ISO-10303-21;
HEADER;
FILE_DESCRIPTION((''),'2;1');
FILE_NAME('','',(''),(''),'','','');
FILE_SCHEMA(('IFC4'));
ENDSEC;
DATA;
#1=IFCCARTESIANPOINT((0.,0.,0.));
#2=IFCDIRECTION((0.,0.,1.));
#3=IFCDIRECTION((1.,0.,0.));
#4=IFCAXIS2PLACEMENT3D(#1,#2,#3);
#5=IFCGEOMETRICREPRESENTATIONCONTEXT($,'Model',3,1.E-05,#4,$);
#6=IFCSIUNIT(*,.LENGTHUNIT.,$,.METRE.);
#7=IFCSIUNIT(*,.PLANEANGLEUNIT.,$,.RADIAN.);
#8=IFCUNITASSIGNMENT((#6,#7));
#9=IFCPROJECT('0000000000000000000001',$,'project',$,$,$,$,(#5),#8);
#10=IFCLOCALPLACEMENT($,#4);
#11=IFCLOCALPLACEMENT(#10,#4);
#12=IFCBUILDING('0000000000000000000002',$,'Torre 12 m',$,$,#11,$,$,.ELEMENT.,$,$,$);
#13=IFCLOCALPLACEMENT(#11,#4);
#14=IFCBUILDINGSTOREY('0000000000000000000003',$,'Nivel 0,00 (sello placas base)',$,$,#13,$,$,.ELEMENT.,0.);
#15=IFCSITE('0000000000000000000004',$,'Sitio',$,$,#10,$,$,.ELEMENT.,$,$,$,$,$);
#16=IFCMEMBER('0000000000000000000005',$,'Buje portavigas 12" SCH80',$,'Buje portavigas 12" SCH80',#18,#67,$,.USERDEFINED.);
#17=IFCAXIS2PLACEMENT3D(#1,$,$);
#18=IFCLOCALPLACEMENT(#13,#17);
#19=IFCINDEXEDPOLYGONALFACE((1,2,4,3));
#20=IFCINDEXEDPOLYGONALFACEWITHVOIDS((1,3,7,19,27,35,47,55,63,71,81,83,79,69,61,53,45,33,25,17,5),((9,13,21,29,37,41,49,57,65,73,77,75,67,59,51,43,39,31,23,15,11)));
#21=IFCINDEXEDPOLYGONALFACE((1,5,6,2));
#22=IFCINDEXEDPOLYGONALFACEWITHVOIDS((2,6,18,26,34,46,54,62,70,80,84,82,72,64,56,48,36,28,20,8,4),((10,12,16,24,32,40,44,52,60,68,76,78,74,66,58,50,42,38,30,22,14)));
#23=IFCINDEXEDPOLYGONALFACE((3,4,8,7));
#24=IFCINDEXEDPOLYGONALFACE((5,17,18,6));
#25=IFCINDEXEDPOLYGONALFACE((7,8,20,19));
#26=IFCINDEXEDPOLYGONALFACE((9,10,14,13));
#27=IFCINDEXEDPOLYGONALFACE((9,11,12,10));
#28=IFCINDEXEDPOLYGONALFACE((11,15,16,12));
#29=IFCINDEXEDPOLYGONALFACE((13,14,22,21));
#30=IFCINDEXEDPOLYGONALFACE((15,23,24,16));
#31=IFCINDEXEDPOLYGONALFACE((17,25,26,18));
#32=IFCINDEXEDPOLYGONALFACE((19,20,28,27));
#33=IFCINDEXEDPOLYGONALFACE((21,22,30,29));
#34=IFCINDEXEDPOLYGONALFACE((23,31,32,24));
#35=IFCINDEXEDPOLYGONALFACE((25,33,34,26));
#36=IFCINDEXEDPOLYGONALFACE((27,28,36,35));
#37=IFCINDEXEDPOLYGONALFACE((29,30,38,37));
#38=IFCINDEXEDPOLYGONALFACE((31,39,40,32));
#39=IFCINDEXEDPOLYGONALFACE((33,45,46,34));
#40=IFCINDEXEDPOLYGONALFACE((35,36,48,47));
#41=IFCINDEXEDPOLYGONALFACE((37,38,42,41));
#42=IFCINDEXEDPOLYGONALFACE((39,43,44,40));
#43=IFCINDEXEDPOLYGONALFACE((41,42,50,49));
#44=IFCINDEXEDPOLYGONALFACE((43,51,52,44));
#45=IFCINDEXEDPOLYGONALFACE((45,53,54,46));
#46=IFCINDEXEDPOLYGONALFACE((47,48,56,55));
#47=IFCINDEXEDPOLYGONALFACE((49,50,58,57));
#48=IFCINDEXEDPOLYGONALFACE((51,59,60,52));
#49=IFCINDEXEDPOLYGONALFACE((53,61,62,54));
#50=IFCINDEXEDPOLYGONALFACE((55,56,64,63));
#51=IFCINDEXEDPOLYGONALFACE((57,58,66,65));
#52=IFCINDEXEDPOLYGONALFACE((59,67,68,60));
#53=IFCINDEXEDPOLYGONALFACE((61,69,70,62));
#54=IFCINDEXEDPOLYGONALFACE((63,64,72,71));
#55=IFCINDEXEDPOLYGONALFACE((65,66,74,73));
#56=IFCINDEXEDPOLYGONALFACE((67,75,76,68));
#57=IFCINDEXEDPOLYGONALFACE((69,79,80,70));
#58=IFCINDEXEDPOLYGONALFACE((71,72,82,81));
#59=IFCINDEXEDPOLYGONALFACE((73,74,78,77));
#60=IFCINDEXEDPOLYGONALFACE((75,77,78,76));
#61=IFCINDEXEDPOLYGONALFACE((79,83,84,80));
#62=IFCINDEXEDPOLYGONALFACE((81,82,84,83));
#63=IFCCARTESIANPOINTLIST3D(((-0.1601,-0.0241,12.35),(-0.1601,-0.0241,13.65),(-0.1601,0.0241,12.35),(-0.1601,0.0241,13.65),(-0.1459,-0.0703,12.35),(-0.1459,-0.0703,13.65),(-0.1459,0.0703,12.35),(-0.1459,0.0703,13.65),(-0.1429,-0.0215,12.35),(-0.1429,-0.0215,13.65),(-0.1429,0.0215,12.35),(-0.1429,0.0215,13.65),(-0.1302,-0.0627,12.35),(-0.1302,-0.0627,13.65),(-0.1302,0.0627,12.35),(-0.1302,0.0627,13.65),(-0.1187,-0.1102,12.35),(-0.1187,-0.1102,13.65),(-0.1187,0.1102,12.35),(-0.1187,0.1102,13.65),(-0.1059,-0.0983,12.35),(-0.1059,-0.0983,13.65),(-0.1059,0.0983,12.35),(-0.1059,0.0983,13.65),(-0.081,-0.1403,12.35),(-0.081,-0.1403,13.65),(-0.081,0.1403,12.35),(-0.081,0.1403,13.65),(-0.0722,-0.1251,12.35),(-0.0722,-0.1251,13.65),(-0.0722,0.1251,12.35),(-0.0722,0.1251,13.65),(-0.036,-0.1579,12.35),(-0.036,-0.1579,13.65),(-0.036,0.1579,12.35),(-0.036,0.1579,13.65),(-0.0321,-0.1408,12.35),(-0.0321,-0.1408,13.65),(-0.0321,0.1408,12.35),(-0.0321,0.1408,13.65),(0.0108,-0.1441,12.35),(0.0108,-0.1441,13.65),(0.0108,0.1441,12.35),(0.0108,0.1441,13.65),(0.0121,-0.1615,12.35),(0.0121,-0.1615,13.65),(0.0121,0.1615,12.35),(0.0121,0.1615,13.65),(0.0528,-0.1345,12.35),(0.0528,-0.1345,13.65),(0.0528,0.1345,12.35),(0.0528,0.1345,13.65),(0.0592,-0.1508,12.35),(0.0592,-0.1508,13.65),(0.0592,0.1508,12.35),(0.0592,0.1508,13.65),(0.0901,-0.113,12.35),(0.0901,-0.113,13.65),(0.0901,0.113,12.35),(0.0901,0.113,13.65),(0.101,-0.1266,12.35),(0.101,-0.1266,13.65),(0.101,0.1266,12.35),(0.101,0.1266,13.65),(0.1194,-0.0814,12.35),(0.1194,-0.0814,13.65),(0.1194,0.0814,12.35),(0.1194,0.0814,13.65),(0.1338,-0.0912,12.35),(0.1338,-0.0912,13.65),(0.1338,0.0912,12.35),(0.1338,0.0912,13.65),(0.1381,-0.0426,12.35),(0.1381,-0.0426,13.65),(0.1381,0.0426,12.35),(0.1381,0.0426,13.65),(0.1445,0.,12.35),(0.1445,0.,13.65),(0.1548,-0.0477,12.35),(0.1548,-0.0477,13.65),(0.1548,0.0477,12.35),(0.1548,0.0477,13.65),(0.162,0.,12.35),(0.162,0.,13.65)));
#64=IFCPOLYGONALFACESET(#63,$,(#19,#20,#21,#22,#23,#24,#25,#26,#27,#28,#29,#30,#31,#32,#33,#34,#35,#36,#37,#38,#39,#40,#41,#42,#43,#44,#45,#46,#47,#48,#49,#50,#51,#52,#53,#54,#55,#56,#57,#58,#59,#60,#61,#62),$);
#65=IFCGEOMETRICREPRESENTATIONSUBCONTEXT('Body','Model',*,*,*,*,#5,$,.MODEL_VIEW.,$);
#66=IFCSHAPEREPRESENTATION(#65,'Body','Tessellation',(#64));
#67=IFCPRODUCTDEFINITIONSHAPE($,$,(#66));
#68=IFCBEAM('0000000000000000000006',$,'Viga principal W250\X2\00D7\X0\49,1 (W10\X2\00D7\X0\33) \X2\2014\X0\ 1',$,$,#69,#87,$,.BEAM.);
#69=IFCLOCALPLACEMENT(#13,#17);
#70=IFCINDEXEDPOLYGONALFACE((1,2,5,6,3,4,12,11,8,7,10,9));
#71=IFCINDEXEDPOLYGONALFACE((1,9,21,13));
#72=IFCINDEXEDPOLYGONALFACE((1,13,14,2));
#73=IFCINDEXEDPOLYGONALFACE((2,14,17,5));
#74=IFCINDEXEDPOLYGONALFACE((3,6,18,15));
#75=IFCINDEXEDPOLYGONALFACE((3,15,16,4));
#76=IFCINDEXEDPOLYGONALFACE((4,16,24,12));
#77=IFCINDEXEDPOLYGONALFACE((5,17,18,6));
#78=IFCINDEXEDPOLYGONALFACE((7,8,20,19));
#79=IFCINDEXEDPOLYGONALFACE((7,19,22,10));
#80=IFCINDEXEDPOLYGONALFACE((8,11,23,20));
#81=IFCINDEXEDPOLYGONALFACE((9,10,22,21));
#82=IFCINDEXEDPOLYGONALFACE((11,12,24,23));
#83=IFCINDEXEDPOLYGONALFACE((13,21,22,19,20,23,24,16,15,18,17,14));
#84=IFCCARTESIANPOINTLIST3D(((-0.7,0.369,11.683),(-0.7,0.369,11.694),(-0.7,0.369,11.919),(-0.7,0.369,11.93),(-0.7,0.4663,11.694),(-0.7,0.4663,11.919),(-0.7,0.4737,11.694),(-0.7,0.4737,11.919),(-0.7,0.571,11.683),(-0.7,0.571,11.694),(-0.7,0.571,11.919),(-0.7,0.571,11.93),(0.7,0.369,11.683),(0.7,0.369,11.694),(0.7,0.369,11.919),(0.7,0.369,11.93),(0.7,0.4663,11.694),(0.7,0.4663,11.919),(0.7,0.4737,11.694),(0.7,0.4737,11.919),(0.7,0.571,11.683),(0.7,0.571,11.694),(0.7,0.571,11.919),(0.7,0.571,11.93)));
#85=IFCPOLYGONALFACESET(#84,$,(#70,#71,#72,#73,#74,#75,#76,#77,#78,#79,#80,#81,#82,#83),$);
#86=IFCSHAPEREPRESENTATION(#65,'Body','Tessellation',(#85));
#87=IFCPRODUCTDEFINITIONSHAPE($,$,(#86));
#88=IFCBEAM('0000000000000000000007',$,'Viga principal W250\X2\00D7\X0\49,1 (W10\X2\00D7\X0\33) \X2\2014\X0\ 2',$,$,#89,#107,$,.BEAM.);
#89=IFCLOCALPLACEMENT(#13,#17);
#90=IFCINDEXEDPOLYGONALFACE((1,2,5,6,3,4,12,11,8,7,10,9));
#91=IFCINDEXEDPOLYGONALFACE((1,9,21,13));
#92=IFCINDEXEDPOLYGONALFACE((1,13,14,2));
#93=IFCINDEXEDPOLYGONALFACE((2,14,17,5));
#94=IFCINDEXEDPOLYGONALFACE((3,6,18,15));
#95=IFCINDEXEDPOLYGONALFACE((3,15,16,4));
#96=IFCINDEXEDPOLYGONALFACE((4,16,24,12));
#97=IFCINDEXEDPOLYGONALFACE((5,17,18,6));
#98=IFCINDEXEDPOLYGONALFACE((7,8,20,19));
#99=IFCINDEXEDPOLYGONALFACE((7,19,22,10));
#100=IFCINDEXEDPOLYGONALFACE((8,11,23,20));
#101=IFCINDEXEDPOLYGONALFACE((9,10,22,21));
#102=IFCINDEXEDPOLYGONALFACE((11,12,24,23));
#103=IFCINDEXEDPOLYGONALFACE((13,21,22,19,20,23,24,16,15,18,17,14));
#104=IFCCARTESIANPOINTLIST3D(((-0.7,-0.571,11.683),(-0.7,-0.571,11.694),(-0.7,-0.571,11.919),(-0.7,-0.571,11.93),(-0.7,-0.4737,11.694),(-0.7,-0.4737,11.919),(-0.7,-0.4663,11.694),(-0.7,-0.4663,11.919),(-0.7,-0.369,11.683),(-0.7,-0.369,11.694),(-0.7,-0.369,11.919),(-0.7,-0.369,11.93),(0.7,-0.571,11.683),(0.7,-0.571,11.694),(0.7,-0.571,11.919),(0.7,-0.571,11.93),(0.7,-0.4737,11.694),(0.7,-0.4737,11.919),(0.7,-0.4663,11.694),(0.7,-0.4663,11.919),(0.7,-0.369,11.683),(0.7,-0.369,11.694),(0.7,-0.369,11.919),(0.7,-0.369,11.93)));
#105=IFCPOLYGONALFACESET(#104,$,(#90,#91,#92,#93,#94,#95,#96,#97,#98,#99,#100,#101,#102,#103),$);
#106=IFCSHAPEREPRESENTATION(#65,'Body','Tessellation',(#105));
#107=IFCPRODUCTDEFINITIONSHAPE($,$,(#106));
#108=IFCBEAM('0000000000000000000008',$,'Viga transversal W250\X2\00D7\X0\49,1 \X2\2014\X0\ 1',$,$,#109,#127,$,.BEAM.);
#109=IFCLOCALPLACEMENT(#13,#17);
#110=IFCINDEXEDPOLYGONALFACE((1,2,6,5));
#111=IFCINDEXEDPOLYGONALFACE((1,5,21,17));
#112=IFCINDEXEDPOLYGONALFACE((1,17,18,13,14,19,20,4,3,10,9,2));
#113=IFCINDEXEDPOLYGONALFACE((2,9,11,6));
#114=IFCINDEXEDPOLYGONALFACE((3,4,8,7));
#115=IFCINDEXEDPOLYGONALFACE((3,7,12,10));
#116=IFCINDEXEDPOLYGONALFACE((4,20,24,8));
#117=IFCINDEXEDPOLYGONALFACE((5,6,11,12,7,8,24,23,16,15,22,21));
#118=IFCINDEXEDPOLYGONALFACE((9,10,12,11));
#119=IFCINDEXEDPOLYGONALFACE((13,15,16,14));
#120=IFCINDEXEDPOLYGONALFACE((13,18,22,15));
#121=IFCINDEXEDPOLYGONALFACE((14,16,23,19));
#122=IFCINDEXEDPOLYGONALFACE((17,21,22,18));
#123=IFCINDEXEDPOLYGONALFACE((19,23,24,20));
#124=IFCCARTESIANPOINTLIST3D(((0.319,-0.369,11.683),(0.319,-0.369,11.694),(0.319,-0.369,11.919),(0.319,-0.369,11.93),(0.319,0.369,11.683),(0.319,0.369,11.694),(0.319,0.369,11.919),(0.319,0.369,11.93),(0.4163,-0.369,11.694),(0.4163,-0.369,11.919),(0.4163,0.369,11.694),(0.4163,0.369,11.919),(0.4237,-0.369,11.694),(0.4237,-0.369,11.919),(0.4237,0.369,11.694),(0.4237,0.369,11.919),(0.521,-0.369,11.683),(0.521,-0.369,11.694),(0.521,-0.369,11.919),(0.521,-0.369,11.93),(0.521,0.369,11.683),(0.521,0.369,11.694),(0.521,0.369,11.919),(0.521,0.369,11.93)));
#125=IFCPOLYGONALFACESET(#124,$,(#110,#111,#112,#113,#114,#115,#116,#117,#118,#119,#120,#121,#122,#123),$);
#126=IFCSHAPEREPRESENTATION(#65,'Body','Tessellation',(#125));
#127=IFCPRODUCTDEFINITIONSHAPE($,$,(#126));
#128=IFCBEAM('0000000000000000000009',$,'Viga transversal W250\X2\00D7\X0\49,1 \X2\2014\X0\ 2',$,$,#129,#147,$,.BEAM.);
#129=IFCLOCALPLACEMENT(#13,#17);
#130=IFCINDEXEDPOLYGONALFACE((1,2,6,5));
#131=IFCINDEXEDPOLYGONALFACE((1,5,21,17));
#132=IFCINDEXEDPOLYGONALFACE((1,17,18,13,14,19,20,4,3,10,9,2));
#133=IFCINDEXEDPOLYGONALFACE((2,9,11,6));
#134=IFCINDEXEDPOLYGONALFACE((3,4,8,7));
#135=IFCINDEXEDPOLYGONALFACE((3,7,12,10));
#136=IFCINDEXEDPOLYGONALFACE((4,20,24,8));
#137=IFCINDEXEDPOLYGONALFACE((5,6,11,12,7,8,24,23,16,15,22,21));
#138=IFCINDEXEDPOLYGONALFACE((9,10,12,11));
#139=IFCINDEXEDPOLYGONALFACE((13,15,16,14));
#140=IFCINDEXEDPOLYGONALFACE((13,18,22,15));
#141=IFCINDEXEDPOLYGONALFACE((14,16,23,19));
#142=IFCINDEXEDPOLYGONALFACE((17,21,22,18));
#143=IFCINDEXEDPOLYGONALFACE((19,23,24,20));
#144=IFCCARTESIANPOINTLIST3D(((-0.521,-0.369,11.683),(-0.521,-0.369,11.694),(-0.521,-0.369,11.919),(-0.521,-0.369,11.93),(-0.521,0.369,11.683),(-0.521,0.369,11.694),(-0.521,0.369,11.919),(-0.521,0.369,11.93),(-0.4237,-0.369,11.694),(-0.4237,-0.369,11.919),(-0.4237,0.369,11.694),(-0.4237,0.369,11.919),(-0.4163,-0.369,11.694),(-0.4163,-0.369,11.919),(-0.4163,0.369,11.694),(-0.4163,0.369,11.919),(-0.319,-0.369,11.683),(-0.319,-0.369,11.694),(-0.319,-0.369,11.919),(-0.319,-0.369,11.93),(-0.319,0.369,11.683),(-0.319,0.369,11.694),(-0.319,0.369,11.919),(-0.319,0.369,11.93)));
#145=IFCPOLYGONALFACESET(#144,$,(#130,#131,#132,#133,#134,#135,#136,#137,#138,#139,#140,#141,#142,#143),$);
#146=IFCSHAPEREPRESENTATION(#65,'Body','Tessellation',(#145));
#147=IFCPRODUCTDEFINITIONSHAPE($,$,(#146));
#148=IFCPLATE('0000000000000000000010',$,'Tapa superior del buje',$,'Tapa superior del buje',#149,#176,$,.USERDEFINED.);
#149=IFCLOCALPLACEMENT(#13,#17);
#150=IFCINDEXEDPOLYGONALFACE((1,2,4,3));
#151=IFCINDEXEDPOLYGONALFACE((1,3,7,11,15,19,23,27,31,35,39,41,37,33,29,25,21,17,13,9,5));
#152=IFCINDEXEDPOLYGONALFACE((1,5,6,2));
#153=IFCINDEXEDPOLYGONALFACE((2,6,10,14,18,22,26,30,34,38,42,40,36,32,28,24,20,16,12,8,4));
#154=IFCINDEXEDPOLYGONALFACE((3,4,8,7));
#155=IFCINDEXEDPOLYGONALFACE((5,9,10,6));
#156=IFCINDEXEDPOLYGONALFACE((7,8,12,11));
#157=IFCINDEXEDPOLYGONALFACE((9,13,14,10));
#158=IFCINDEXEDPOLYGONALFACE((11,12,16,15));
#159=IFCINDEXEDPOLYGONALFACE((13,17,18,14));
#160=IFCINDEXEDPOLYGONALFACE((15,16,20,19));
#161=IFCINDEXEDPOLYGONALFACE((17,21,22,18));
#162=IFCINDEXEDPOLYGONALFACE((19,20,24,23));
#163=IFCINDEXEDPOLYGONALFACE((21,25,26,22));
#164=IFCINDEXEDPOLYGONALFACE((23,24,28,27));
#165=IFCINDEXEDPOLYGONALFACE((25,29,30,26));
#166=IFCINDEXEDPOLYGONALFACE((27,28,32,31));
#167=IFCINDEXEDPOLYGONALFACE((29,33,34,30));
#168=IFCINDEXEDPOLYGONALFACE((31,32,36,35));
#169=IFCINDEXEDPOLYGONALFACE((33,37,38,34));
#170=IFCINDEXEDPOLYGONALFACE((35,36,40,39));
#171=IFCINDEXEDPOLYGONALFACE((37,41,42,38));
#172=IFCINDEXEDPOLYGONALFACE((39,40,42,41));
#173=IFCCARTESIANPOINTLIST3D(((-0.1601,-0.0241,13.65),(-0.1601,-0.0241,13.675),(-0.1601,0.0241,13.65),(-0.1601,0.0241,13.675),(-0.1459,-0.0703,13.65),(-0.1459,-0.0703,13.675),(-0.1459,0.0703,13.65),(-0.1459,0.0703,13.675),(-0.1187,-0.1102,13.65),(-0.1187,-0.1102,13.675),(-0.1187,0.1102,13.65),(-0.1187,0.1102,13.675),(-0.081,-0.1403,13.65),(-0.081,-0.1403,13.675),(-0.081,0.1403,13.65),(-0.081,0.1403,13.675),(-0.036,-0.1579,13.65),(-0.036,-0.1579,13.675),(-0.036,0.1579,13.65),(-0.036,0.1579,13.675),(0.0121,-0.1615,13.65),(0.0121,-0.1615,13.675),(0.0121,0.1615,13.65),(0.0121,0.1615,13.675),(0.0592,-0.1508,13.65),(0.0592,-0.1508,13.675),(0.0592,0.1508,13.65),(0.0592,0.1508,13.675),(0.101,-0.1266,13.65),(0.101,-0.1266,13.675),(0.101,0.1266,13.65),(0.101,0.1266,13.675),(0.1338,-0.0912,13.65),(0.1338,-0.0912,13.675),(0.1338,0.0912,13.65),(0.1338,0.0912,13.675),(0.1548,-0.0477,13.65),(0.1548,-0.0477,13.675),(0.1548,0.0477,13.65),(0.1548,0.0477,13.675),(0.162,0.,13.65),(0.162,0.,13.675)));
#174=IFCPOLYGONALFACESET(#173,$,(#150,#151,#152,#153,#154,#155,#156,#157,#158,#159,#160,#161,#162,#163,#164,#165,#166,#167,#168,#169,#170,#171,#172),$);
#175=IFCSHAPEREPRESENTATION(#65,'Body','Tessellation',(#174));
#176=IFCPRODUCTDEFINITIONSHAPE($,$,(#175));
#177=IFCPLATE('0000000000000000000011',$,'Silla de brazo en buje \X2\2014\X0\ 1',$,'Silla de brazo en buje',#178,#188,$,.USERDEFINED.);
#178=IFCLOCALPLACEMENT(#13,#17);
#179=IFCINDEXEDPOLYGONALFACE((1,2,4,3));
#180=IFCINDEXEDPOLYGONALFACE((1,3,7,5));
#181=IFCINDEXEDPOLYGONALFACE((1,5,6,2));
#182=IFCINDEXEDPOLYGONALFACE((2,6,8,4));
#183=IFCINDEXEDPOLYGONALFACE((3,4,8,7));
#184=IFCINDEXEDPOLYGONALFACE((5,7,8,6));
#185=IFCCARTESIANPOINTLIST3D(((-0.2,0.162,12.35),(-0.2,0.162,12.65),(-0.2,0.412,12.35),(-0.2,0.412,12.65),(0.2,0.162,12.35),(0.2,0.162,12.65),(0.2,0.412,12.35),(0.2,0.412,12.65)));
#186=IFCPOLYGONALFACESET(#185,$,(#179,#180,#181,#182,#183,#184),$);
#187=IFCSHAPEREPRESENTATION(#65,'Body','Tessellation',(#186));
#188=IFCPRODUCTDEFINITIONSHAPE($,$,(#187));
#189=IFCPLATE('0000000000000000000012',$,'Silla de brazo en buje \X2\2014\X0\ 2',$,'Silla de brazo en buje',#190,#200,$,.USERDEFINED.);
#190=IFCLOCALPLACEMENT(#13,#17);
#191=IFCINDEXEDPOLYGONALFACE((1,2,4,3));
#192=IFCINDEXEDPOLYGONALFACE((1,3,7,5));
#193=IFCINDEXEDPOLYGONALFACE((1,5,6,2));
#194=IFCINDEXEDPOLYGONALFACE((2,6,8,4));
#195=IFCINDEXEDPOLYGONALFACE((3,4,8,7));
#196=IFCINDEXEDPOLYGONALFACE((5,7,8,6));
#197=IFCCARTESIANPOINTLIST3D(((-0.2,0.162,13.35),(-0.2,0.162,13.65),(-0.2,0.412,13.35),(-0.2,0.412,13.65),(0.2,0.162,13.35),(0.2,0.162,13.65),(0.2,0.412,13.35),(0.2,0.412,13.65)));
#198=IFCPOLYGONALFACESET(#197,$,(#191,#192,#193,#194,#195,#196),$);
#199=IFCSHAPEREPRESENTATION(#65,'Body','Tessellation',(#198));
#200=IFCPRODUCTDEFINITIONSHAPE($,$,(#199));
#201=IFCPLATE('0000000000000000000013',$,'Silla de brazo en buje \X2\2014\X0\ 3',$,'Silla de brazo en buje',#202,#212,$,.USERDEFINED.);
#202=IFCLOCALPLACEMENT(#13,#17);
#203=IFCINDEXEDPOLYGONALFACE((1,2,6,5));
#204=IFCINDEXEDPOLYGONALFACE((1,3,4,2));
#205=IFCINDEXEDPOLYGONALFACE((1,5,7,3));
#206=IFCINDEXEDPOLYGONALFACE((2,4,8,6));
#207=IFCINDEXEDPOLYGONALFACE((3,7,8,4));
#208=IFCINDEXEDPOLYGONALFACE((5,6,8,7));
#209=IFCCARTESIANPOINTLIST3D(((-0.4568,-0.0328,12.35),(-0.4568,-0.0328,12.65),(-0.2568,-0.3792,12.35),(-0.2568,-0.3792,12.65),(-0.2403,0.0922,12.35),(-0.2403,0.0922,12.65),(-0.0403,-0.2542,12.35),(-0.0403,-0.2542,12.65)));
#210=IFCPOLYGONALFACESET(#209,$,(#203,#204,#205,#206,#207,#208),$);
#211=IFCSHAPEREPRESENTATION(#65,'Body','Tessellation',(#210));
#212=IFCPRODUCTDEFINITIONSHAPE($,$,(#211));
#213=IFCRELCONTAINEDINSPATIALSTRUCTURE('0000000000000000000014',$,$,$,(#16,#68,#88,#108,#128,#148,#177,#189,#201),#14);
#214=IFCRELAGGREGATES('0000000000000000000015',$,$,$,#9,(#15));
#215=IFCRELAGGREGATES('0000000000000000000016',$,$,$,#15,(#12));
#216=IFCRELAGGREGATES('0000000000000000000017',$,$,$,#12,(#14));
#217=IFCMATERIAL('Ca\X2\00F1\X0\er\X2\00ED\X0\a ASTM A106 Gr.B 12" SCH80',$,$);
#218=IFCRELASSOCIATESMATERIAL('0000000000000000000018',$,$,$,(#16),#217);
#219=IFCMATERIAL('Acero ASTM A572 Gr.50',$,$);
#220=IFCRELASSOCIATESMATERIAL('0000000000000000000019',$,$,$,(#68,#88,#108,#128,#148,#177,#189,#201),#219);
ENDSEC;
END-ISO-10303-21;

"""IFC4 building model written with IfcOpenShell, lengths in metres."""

from ifc_helpers import new_model, si_unit, frame, origin, origin_with_axes, origin_2d, place, context, subcontext, project, spatial, rectangle, circle, hollow_circle, i_section, extrude, material, element, save


model = new_model("IFC4")

# Units and contexts
model_context = context("Model", 3, precision=1e-05, world=origin_with_axes())
body_context = subcontext(model_context, "Body", "Model", "MODEL_VIEW")
ifc_project = project(units=[si_unit("LENGTHUNIT", "METRE"), si_unit("PLANEANGLEUNIT", "RADIAN")], contexts=[model_context])

# Site, building, storey
site_placement = place(None, origin_with_axes())
site = spatial("IfcSite", under=ifc_project, at=site_placement, Name="Sitio", CompositionType="ELEMENT")
building_placement = place(site_placement, origin_with_axes())
building = spatial("IfcBuilding", under=site, at=building_placement, Name="Torre 12 m", CompositionType="ELEMENT")
storey_placement = place(building_placement, origin_with_axes())
storey = spatial("IfcBuildingStorey", under=building, at=storey_placement, Name="Nivel 0,00 (sello placas base)", CompositionType="ELEMENT", Elevation=0.0)

# Member
ifc_material_1 = material(Name="Cañería ASTM A106 Gr.B 12\" SCH80")
member_placement = place(storey_placement, frame((0.0, 0.0, 12.35), z_axis=(0.0, 0.0, 1.0), x_axis=(1.0, 0.0, 0.0)))
element("IfcMember", 1, at=member_placement, inside=storey, material=ifc_material_1, Name="Buje portavigas 12\" SCH80", ObjectType="Buje portavigas 12\" SCH80", PredefinedType="USERDEFINED", context=body_context, shape_type="SweptSolid", body=[
    extrude(hollow_circle(Radius=0.162, WallThickness=0.0175, at=origin_2d()), origin(), (0.0, 0.0, 1.0), 1.3),
])

# Beams
ifc_material_2 = material(Name="Acero ASTM A572 Gr.50")
for number, where, z_axis, x_axis, name in (
    (2, (-0.7, 0.47, 11.8065), (1.0, 0.0, 0.0), (0.0, 1.0, 0.0), "Viga principal W250×49,1 (W10×33) — 1"),
    (3, (-0.7, -0.47, 11.8065), (1.0, 0.0, 0.0), (0.0, 1.0, 0.0), "Viga principal W250×49,1 (W10×33) — 2"),
):
    element("IfcBeam", number, at=place(storey_placement, frame(where, z_axis=z_axis, x_axis=x_axis)), inside=storey, material=ifc_material_2, Name=name, PredefinedType="BEAM", context=body_context, shape_type="SweptSolid", body=[
        extrude(i_section(OverallWidth=0.202, OverallDepth=0.247, WebThickness=0.0074, FlangeThickness=0.011, at=origin_2d()), origin(), (0.0, 0.0, 1.0), 1.4),
    ])
for number, where, z_axis, x_axis, name in (
    (4, (0.42, -0.369, 11.8065), (0.0, 1.0, 0.0), (1.0, 0.0, 0.0), "Viga transversal W250×49,1 — 1"),
    (5, (-0.42, -0.369, 11.8065), (0.0, 1.0, 0.0), (1.0, 0.0, 0.0), "Viga transversal W250×49,1 — 2"),
):
    element("IfcBeam", number, at=place(storey_placement, frame(where, z_axis=z_axis, x_axis=x_axis)), inside=storey, material=ifc_material_2, Name=name, PredefinedType="BEAM", context=body_context, shape_type="SweptSolid", body=[
        extrude(i_section(OverallWidth=0.202, OverallDepth=0.247, WebThickness=0.0074, FlangeThickness=0.011, at=origin_2d()), origin(), (0.0, 0.0, 1.0), 0.738),
    ])

# Plates
plate_1_placement = place(storey_placement, frame((0.0, 0.0, 13.65), z_axis=(0.0, 0.0, 1.0), x_axis=(1.0, 0.0, 0.0)))
element("IfcPlate", 6, at=plate_1_placement, inside=storey, material=ifc_material_2, Name="Tapa superior del buje", ObjectType="Tapa superior del buje", PredefinedType="USERDEFINED", context=body_context, shape_type="SweptSolid", body=[
    extrude(circle(Radius=0.162, at=origin_2d()), origin(), (0.0, 0.0, 1.0), 0.025),
])
for number, where, z_axis, x_axis, name in (
    (7, (0.0, 0.287, 12.35), (0.0, 0.0, 1.0), (0.0, 1.0, 0.0), "Silla de brazo en buje — 1"),
    (8, (0.0, 0.287, 13.35), (0.0, 0.0, 1.0), (0.0, 1.0, 0.0), "Silla de brazo en buje — 2"),
    (9, (-0.2485, -0.1435, 12.35), (0.0, 0.0, 1.0), (-0.866025, -0.5, 0.0), "Silla de brazo en buje — 3"),
):
    element("IfcPlate", number, at=place(storey_placement, frame(where, z_axis=z_axis, x_axis=x_axis)), inside=storey, material=ifc_material_2, Name=name, ObjectType="Silla de brazo en buje", PredefinedType="USERDEFINED", context=body_context, shape_type="SweptSolid", body=[
        extrude(rectangle(XDim=0.25, YDim=0.4, at=origin_2d()), origin(), (0.0, 0.0, 1.0), 0.3),
    ])

save(model, "model.ifc")
